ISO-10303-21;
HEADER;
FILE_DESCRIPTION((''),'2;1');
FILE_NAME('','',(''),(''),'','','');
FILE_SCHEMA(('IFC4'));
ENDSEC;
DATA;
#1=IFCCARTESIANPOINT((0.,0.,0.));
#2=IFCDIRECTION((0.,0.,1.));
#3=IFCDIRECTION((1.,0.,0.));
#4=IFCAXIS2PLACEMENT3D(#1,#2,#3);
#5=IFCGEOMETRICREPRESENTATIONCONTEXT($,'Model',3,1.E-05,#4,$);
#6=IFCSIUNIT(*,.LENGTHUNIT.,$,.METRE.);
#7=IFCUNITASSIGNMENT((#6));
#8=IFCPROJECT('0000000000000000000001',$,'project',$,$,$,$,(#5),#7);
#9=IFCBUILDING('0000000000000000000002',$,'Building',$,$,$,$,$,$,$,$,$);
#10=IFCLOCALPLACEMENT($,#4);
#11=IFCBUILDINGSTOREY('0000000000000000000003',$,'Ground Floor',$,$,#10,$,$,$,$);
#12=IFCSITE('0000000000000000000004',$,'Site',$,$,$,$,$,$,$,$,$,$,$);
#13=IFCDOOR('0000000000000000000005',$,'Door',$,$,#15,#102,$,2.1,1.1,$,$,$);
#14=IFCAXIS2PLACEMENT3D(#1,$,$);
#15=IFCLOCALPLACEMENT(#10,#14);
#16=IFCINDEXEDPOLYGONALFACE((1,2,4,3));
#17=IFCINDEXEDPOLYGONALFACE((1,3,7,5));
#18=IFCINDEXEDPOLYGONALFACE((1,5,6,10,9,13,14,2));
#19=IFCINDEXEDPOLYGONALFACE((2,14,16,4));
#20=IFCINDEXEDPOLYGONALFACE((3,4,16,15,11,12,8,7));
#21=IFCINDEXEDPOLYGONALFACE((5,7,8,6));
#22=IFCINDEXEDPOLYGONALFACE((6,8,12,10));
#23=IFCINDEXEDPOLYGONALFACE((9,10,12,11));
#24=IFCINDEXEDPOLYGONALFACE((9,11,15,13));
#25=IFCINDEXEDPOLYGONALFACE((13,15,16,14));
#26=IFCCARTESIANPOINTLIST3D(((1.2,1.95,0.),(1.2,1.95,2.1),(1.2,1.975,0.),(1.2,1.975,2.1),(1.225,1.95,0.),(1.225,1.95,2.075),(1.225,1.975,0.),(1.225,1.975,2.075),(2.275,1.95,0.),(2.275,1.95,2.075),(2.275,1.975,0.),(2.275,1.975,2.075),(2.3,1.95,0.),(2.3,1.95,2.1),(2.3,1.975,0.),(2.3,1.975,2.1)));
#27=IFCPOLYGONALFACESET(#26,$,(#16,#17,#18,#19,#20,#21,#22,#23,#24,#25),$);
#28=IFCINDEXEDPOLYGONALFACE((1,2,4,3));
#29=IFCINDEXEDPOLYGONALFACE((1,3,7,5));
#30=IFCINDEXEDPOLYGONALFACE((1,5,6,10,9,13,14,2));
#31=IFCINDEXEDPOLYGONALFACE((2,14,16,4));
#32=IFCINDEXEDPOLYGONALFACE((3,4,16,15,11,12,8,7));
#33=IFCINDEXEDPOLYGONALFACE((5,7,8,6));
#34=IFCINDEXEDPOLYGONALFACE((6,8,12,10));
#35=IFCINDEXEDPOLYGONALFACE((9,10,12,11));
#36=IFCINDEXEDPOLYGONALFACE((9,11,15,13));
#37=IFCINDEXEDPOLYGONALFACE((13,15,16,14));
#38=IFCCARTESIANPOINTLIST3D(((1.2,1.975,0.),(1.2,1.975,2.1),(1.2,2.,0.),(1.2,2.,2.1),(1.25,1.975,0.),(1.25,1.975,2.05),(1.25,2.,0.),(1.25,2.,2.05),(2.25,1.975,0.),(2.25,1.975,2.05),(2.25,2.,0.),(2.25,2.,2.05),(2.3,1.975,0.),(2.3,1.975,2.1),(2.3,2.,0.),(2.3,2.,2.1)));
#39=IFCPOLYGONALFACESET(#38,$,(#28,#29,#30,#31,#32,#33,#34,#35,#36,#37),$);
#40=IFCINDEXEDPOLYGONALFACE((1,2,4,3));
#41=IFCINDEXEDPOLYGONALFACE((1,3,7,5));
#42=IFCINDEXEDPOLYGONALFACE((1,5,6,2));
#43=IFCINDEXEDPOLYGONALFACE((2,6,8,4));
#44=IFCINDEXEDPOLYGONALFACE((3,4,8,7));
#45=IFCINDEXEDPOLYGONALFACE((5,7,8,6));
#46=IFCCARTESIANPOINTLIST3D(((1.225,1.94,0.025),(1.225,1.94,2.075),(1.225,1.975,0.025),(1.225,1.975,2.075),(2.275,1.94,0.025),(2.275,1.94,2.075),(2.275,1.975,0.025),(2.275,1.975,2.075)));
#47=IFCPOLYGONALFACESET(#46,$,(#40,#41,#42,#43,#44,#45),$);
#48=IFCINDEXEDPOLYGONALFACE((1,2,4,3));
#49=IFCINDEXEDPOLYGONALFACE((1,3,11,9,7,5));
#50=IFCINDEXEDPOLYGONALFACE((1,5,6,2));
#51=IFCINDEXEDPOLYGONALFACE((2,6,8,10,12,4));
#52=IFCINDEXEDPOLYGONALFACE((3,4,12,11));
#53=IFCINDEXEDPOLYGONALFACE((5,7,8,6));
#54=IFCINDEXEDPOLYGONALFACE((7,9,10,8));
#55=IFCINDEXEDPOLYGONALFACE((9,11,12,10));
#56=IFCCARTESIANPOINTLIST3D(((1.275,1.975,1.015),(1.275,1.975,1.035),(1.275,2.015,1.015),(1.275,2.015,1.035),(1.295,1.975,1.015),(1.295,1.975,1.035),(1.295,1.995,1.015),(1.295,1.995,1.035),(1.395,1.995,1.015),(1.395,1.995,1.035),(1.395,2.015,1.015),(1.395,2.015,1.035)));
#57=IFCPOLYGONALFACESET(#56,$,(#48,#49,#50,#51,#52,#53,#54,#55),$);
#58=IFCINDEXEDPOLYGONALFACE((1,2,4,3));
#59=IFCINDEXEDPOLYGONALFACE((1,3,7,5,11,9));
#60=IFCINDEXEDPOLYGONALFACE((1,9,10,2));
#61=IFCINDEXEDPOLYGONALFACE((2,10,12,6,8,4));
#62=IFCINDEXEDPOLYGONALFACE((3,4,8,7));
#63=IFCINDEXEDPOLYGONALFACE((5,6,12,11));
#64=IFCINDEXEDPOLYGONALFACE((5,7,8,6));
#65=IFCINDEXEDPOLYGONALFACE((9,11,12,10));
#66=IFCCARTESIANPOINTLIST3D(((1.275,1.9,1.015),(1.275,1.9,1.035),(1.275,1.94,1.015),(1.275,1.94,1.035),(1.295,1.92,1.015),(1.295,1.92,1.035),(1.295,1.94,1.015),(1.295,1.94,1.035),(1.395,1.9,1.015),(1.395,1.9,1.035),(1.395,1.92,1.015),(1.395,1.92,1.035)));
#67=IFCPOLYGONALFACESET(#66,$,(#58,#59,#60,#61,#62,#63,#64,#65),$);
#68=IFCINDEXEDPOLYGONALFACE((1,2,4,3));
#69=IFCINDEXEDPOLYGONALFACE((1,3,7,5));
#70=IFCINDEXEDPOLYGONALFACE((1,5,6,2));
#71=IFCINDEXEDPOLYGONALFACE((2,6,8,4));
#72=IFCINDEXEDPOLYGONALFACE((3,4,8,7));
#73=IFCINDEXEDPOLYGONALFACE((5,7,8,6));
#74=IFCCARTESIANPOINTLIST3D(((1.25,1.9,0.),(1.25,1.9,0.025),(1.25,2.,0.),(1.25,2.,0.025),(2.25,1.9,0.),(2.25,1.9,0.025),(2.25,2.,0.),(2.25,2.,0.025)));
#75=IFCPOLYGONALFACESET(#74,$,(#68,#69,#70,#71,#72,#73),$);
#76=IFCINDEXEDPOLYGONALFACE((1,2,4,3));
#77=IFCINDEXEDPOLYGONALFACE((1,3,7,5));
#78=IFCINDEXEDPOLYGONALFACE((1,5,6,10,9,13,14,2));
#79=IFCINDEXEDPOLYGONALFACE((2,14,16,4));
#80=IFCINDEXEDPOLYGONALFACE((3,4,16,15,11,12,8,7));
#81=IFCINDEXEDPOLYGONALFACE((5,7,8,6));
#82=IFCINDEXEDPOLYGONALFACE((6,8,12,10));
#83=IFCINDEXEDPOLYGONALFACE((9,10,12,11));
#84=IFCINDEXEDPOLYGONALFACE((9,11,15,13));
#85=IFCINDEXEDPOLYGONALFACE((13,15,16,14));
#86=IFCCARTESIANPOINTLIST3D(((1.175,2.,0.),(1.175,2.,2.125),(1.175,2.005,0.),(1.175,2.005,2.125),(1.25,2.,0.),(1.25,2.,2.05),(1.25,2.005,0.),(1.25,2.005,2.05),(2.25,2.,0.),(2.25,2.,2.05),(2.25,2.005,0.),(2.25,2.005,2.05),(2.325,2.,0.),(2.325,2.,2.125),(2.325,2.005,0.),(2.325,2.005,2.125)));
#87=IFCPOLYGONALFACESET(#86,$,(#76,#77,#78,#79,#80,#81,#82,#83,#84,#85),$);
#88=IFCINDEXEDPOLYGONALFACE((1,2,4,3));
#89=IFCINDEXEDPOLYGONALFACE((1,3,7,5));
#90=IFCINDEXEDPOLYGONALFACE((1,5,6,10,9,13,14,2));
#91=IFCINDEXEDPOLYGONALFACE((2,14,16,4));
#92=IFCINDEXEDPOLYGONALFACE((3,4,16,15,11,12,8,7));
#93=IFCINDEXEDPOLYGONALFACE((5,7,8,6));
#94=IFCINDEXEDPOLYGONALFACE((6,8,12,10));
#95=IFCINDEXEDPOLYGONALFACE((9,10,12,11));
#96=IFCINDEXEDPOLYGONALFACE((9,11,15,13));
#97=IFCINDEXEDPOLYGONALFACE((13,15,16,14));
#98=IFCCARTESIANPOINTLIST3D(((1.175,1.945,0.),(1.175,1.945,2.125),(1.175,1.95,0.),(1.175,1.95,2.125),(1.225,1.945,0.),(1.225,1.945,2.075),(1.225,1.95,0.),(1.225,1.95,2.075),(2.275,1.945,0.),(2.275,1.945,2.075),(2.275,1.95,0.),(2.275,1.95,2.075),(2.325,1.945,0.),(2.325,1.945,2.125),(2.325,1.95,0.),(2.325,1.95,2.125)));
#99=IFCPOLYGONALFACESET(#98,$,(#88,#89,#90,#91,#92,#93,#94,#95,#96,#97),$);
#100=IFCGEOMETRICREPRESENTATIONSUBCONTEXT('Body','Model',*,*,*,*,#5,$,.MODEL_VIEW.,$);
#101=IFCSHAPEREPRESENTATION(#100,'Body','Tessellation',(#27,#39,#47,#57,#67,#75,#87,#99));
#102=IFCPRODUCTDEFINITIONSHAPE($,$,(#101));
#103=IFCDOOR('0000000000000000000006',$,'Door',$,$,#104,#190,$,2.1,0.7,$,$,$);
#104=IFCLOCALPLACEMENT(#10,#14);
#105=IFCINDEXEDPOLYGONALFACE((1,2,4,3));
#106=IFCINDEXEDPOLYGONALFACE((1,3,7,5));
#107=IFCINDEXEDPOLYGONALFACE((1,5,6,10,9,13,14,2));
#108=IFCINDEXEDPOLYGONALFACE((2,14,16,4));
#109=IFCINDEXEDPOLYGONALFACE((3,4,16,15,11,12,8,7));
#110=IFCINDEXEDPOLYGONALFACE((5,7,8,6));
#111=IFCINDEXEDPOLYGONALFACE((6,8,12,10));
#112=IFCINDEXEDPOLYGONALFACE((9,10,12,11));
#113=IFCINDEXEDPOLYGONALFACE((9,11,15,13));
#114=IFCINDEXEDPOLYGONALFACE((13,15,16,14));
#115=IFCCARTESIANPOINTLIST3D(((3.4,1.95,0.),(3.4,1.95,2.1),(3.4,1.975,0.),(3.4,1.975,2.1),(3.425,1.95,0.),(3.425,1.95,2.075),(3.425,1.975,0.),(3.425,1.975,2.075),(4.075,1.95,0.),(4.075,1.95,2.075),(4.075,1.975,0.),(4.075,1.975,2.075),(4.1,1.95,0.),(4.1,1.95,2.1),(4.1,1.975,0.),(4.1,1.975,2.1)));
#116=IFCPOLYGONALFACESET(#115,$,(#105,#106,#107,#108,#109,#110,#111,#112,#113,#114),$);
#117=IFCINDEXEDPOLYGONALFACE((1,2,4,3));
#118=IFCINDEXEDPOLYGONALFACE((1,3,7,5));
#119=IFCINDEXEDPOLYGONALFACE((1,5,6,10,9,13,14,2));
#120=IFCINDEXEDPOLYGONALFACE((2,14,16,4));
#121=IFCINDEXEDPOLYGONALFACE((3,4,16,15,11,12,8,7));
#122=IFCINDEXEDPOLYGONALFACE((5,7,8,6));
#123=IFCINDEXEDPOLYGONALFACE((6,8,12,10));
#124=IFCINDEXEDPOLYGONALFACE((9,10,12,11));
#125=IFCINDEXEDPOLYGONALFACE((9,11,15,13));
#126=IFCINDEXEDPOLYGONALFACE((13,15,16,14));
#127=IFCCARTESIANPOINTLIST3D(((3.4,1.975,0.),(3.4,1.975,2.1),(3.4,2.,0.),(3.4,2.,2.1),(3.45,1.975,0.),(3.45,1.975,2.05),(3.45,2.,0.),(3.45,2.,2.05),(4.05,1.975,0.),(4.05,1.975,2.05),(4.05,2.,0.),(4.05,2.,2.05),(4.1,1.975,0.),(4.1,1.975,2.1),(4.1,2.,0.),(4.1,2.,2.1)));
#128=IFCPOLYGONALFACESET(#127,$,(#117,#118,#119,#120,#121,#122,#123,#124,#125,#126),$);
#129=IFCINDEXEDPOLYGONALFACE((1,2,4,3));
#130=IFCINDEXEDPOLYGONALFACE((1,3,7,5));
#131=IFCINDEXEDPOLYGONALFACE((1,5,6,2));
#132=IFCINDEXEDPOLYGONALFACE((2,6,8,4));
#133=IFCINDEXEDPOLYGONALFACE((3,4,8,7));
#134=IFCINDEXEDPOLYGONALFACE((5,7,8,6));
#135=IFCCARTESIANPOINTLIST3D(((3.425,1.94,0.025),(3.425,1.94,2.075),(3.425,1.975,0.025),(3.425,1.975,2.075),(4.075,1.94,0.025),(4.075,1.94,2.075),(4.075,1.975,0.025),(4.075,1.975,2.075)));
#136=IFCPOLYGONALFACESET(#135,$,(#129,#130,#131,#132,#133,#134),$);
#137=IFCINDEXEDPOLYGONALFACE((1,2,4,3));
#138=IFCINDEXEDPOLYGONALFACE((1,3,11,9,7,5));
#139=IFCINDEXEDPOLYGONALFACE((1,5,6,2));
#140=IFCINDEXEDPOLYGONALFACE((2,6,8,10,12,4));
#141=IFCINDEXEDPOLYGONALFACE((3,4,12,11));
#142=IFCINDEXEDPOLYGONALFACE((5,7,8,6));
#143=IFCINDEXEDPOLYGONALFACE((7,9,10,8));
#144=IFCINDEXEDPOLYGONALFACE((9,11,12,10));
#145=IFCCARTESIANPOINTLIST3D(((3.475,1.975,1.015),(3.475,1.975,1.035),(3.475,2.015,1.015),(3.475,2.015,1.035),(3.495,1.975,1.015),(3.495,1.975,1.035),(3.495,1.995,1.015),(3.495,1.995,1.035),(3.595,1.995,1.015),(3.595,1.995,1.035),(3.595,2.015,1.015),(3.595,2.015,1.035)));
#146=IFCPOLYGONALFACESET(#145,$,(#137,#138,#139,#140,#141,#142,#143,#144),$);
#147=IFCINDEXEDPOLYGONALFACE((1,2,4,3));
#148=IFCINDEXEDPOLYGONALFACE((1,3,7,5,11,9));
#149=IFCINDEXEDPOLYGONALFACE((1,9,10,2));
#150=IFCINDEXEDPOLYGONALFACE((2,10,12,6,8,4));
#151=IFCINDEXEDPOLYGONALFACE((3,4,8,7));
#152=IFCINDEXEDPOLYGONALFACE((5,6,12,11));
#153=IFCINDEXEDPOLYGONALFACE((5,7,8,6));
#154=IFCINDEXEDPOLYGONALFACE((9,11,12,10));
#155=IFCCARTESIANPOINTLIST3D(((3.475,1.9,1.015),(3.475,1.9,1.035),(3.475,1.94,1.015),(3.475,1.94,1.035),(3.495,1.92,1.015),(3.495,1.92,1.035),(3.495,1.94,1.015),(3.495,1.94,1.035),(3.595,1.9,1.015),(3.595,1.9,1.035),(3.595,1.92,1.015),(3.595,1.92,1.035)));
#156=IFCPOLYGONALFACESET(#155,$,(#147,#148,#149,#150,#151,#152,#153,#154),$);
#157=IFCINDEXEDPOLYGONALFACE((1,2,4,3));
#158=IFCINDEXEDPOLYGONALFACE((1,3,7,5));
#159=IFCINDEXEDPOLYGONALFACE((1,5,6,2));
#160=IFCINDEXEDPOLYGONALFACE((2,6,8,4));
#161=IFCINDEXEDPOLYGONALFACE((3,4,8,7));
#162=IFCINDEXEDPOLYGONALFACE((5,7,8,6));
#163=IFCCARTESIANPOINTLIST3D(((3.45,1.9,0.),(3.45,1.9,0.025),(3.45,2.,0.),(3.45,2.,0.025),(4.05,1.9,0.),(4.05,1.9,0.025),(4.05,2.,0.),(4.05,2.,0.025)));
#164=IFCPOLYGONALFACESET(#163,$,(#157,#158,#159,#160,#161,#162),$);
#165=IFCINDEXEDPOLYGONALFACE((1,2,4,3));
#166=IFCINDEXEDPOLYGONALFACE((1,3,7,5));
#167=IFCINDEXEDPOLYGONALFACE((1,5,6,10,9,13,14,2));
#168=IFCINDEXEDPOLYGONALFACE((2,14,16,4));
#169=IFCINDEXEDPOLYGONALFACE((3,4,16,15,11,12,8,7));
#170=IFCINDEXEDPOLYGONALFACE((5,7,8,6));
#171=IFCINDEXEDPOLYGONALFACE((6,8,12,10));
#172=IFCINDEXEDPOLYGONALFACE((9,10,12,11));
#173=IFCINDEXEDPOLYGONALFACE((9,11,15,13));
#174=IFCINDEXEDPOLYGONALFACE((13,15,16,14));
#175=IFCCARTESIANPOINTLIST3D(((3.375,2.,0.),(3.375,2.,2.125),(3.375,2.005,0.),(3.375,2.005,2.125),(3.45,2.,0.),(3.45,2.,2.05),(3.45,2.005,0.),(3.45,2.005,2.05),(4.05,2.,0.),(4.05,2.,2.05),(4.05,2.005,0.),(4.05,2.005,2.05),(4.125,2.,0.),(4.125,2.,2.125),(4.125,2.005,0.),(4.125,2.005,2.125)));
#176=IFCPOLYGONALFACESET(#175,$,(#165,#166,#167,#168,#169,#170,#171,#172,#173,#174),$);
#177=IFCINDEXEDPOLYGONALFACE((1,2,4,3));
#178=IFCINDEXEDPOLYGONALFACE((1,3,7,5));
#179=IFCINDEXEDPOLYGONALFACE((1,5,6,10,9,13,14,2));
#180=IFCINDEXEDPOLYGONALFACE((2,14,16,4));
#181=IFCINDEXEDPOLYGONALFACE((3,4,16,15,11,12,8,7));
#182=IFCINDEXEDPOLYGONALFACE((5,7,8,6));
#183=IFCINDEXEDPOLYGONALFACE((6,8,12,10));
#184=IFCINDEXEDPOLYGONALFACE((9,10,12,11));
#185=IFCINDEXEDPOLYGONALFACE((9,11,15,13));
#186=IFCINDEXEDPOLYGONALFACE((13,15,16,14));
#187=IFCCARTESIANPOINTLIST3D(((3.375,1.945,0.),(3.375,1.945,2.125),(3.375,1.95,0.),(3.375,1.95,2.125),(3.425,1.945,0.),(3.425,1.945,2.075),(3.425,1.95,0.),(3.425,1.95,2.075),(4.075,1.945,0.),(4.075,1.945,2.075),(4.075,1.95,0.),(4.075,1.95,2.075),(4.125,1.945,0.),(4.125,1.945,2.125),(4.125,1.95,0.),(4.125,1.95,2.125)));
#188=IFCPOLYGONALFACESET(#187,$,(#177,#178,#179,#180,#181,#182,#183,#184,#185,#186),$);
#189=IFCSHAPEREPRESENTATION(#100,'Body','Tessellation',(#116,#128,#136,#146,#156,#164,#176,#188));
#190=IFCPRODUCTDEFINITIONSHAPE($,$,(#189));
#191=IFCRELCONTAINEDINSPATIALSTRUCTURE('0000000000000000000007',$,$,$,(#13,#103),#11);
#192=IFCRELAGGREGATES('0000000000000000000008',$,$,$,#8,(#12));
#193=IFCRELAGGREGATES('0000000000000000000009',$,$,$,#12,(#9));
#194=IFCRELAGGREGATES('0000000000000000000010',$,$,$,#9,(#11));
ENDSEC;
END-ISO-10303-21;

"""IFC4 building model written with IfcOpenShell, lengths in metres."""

from ifc_helpers import new_model, si_unit, frame, origin_with_axes, place, context, subcontext, project, spatial, line, indexed_curve, outline, extrude, element, save


model = new_model("IFC4")

# Units and contexts
model_context = context("Model", 3, precision=1e-05, world=origin_with_axes())
body_context = subcontext(model_context, "Body", "Model", "MODEL_VIEW")
ifc_project = project(units=[si_unit("LENGTHUNIT", "METRE")], contexts=[model_context])

# Site, building, storey
site = spatial("IfcSite", under=ifc_project, Name="Site")
building = spatial("IfcBuilding", under=site, Name="Building")
storey_placement = place(None, origin_with_axes())
storey = spatial("IfcBuildingStorey", under=building, at=storey_placement, Name="Ground Floor")

# Doors
door_1_placement = place(storey_placement, frame((2.3, 2.0, 0.0), z_axis=(0.0, 0.0, 1.0), x_axis=(-1.0, 0.0, 0.0)))
element("IfcDoor", 1, at=door_1_placement, inside=storey, Name="Door", OverallHeight=2.1, OverallWidth=1.1, context=body_context, shape_type="SweptSolid", body=[
    extrude(outline(indexed_curve([(0.0, 0.0), (0.0, 2.1), (1.1, 2.1), (1.1, 0.0), (1.075, 0.0), (1.075, 2.075), (0.025, 2.075), (0.025, 0.0)], segments=[line(1, 2, 3, 4, 5, 6, 7, 8, 1)])), frame((0.0, 0.025, 0.0), z_axis=(0.0, -1.0, 0.0), x_axis=(1.0, 0.0, 0.0)), (0.0, 0.0, -1.0), 0.025),
    extrude(outline(indexed_curve([(0.0, 0.0), (0.0, 2.1), (1.1, 2.1), (1.1, 0.0), (1.05, 0.0), (1.05, 2.05), (0.05, 2.05), (0.05, 0.0)], segments=[line(1, 2, 3, 4, 5, 6, 7, 8, 1)])), frame((0.0, 0.0, 0.0), z_axis=(0.0, -1.0, 0.0), x_axis=(1.0, 0.0, 0.0)), (0.0, 0.0, -1.0), 0.025),
    extrude(outline(indexed_curve([(0.0, 0.0), (1.05, 0.0), (1.05, 0.035), (0.0, 0.035)], segments=[line(1, 2, 3, 4, 1)])), frame((0.025, 0.025, 0.025), z_axis=(0.0, 0.0, 1.0), x_axis=(1.0, 0.0, 0.0)), (0.0, 0.0, 1.0), 2.05),
    extrude(outline(indexed_curve([(0.0, 0.0), (0.0, -0.04), (-0.12, -0.04), (-0.12, -0.02), (-0.02, -0.02), (-0.02, 0.0)], segments=[line(1, 2, 3, 4, 5, 6, 1)])), frame((1.025, 0.025, 1.015), z_axis=(0.0, 0.0, 1.0), x_axis=(1.0, 0.0, 0.0)), (0.0, 0.0, 1.0), 0.02),
    extrude(outline(indexed_curve([(0.0, 0.0), (0.0, 0.04), (-0.12, 0.04), (-0.12, 0.02), (-0.02, 0.02), (-0.02, 0.0)], segments=[line(1, 2, 3, 4, 5, 6, 1)])), frame((1.025, 0.06, 1.015), z_axis=(0.0, 0.0, 1.0), x_axis=(1.0, 0.0, 0.0)), (0.0, 0.0, 1.0), 0.02),
    extrude(outline(indexed_curve([(0.0, 0.0), (1.0, 0.0), (1.0, 0.1), (0.0, 0.1)], segments=[line(1, 2, 3, 4, 1)])), frame((0.05, 0.0, 0.0), z_axis=(0.0, 0.0, 1.0), x_axis=(1.0, 0.0, 0.0)), (0.0, 0.0, 1.0), 0.025),
    extrude(outline(indexed_curve([(0.0, 0.0), (0.0, 2.125), (1.15, 2.125), (1.15, 0.0), (1.075, 0.0), (1.075, 2.05), (0.075, 2.05), (0.075, 0.0)], segments=[line(1, 2, 3, 4, 5, 6, 7, 8, 1)])), frame((-0.025, -0.005, 0.0), z_axis=(0.0, -1.0, 0.0), x_axis=(1.0, 0.0, 0.0)), (0.0, 0.0, -1.0), 0.005),
    extrude(outline(indexed_curve([(0.0, 0.0), (0.0, 2.125), (1.15, 2.125), (1.15, 0.0), (1.1, 0.0), (1.1, 2.075), (0.05, 2.075), (0.05, 0.0)], segments=[line(1, 2, 3, 4, 5, 6, 7, 8, 1)])), frame((-0.025, 0.05, 0.0), z_axis=(0.0, -1.0, 0.0), x_axis=(1.0, 0.0, 0.0)), (0.0, 0.0, -1.0), 0.005),
])
door_2_placement = place(storey_placement, frame((4.1, 2.0, 0.0), z_axis=(0.0, 0.0, 1.0), x_axis=(-1.0, 0.0, 0.0)))
element("IfcDoor", 2, at=door_2_placement, inside=storey, Name="Door", OverallHeight=2.1, OverallWidth=0.7, context=body_context, shape_type="SweptSolid", body=[
    extrude(outline(indexed_curve([(0.0, 0.0), (0.0, 2.1), (0.7, 2.1), (0.7, 0.0), (0.675, 0.0), (0.675, 2.075), (0.025, 2.075), (0.025, 0.0)], segments=[line(1, 2, 3, 4, 5, 6, 7, 8, 1)])), frame((0.0, 0.025, 0.0), z_axis=(0.0, -1.0, 0.0), x_axis=(1.0, 0.0, 0.0)), (0.0, 0.0, -1.0), 0.025),
    extrude(outline(indexed_curve([(0.0, 0.0), (0.0, 2.1), (0.7, 2.1), (0.7, 0.0), (0.65, 0.0), (0.65, 2.05), (0.05, 2.05), (0.05, 0.0)], segments=[line(1, 2, 3, 4, 5, 6, 7, 8, 1)])), frame((0.0, 0.0, 0.0), z_axis=(0.0, -1.0, 0.0), x_axis=(1.0, 0.0, 0.0)), (0.0, 0.0, -1.0), 0.025),
    extrude(outline(indexed_curve([(0.0, 0.0), (0.65, 0.0), (0.65, 0.035), (0.0, 0.035)], segments=[line(1, 2, 3, 4, 1)])), frame((0.025, 0.025, 0.025), z_axis=(0.0, 0.0, 1.0), x_axis=(1.0, 0.0, 0.0)), (0.0, 0.0, 1.0), 2.05),
    extrude(outline(indexed_curve([(0.0, 0.0), (0.0, -0.04), (-0.12, -0.04), (-0.12, -0.02), (-0.02, -0.02), (-0.02, 0.0)], segments=[line(1, 2, 3, 4, 5, 6, 1)])), frame((0.625, 0.025, 1.015), z_axis=(0.0, 0.0, 1.0), x_axis=(1.0, 0.0, 0.0)), (0.0, 0.0, 1.0), 0.02),
    extrude(outline(indexed_curve([(0.0, 0.0), (0.0, 0.04), (-0.12, 0.04), (-0.12, 0.02), (-0.02, 0.02), (-0.02, 0.0)], segments=[line(1, 2, 3, 4, 5, 6, 1)])), frame((0.625, 0.06, 1.015), z_axis=(0.0, 0.0, 1.0), x_axis=(1.0, 0.0, 0.0)), (0.0, 0.0, 1.0), 0.02),
    extrude(outline(indexed_curve([(0.0, 0.0), (0.6, 0.0), (0.6, 0.1), (0.0, 0.1)], segments=[line(1, 2, 3, 4, 1)])), frame((0.05, 0.0, 0.0), z_axis=(0.0, 0.0, 1.0), x_axis=(1.0, 0.0, 0.0)), (0.0, 0.0, 1.0), 0.025),
    extrude(outline(indexed_curve([(0.0, 0.0), (0.0, 2.125), (0.75, 2.125), (0.75, 0.0), (0.675, 0.0), (0.675, 2.05), (0.075, 2.05), (0.075, 0.0)], segments=[line(1, 2, 3, 4, 5, 6, 7, 8, 1)])), frame((-0.025, -0.005, 0.0), z_axis=(0.0, -1.0, 0.0), x_axis=(1.0, 0.0, 0.0)), (0.0, 0.0, -1.0), 0.005),
    extrude(outline(indexed_curve([(0.0, 0.0), (0.0, 2.125), (0.75, 2.125), (0.75, 0.0), (0.7, 0.0), (0.7, 2.075), (0.05, 2.075), (0.05, 0.0)], segments=[line(1, 2, 3, 4, 5, 6, 7, 8, 1)])), frame((-0.025, 0.05, 0.0), z_axis=(0.0, -1.0, 0.0), x_axis=(1.0, 0.0, 0.0)), (0.0, 0.0, -1.0), 0.005),
])

save(model, "model.ifc")
